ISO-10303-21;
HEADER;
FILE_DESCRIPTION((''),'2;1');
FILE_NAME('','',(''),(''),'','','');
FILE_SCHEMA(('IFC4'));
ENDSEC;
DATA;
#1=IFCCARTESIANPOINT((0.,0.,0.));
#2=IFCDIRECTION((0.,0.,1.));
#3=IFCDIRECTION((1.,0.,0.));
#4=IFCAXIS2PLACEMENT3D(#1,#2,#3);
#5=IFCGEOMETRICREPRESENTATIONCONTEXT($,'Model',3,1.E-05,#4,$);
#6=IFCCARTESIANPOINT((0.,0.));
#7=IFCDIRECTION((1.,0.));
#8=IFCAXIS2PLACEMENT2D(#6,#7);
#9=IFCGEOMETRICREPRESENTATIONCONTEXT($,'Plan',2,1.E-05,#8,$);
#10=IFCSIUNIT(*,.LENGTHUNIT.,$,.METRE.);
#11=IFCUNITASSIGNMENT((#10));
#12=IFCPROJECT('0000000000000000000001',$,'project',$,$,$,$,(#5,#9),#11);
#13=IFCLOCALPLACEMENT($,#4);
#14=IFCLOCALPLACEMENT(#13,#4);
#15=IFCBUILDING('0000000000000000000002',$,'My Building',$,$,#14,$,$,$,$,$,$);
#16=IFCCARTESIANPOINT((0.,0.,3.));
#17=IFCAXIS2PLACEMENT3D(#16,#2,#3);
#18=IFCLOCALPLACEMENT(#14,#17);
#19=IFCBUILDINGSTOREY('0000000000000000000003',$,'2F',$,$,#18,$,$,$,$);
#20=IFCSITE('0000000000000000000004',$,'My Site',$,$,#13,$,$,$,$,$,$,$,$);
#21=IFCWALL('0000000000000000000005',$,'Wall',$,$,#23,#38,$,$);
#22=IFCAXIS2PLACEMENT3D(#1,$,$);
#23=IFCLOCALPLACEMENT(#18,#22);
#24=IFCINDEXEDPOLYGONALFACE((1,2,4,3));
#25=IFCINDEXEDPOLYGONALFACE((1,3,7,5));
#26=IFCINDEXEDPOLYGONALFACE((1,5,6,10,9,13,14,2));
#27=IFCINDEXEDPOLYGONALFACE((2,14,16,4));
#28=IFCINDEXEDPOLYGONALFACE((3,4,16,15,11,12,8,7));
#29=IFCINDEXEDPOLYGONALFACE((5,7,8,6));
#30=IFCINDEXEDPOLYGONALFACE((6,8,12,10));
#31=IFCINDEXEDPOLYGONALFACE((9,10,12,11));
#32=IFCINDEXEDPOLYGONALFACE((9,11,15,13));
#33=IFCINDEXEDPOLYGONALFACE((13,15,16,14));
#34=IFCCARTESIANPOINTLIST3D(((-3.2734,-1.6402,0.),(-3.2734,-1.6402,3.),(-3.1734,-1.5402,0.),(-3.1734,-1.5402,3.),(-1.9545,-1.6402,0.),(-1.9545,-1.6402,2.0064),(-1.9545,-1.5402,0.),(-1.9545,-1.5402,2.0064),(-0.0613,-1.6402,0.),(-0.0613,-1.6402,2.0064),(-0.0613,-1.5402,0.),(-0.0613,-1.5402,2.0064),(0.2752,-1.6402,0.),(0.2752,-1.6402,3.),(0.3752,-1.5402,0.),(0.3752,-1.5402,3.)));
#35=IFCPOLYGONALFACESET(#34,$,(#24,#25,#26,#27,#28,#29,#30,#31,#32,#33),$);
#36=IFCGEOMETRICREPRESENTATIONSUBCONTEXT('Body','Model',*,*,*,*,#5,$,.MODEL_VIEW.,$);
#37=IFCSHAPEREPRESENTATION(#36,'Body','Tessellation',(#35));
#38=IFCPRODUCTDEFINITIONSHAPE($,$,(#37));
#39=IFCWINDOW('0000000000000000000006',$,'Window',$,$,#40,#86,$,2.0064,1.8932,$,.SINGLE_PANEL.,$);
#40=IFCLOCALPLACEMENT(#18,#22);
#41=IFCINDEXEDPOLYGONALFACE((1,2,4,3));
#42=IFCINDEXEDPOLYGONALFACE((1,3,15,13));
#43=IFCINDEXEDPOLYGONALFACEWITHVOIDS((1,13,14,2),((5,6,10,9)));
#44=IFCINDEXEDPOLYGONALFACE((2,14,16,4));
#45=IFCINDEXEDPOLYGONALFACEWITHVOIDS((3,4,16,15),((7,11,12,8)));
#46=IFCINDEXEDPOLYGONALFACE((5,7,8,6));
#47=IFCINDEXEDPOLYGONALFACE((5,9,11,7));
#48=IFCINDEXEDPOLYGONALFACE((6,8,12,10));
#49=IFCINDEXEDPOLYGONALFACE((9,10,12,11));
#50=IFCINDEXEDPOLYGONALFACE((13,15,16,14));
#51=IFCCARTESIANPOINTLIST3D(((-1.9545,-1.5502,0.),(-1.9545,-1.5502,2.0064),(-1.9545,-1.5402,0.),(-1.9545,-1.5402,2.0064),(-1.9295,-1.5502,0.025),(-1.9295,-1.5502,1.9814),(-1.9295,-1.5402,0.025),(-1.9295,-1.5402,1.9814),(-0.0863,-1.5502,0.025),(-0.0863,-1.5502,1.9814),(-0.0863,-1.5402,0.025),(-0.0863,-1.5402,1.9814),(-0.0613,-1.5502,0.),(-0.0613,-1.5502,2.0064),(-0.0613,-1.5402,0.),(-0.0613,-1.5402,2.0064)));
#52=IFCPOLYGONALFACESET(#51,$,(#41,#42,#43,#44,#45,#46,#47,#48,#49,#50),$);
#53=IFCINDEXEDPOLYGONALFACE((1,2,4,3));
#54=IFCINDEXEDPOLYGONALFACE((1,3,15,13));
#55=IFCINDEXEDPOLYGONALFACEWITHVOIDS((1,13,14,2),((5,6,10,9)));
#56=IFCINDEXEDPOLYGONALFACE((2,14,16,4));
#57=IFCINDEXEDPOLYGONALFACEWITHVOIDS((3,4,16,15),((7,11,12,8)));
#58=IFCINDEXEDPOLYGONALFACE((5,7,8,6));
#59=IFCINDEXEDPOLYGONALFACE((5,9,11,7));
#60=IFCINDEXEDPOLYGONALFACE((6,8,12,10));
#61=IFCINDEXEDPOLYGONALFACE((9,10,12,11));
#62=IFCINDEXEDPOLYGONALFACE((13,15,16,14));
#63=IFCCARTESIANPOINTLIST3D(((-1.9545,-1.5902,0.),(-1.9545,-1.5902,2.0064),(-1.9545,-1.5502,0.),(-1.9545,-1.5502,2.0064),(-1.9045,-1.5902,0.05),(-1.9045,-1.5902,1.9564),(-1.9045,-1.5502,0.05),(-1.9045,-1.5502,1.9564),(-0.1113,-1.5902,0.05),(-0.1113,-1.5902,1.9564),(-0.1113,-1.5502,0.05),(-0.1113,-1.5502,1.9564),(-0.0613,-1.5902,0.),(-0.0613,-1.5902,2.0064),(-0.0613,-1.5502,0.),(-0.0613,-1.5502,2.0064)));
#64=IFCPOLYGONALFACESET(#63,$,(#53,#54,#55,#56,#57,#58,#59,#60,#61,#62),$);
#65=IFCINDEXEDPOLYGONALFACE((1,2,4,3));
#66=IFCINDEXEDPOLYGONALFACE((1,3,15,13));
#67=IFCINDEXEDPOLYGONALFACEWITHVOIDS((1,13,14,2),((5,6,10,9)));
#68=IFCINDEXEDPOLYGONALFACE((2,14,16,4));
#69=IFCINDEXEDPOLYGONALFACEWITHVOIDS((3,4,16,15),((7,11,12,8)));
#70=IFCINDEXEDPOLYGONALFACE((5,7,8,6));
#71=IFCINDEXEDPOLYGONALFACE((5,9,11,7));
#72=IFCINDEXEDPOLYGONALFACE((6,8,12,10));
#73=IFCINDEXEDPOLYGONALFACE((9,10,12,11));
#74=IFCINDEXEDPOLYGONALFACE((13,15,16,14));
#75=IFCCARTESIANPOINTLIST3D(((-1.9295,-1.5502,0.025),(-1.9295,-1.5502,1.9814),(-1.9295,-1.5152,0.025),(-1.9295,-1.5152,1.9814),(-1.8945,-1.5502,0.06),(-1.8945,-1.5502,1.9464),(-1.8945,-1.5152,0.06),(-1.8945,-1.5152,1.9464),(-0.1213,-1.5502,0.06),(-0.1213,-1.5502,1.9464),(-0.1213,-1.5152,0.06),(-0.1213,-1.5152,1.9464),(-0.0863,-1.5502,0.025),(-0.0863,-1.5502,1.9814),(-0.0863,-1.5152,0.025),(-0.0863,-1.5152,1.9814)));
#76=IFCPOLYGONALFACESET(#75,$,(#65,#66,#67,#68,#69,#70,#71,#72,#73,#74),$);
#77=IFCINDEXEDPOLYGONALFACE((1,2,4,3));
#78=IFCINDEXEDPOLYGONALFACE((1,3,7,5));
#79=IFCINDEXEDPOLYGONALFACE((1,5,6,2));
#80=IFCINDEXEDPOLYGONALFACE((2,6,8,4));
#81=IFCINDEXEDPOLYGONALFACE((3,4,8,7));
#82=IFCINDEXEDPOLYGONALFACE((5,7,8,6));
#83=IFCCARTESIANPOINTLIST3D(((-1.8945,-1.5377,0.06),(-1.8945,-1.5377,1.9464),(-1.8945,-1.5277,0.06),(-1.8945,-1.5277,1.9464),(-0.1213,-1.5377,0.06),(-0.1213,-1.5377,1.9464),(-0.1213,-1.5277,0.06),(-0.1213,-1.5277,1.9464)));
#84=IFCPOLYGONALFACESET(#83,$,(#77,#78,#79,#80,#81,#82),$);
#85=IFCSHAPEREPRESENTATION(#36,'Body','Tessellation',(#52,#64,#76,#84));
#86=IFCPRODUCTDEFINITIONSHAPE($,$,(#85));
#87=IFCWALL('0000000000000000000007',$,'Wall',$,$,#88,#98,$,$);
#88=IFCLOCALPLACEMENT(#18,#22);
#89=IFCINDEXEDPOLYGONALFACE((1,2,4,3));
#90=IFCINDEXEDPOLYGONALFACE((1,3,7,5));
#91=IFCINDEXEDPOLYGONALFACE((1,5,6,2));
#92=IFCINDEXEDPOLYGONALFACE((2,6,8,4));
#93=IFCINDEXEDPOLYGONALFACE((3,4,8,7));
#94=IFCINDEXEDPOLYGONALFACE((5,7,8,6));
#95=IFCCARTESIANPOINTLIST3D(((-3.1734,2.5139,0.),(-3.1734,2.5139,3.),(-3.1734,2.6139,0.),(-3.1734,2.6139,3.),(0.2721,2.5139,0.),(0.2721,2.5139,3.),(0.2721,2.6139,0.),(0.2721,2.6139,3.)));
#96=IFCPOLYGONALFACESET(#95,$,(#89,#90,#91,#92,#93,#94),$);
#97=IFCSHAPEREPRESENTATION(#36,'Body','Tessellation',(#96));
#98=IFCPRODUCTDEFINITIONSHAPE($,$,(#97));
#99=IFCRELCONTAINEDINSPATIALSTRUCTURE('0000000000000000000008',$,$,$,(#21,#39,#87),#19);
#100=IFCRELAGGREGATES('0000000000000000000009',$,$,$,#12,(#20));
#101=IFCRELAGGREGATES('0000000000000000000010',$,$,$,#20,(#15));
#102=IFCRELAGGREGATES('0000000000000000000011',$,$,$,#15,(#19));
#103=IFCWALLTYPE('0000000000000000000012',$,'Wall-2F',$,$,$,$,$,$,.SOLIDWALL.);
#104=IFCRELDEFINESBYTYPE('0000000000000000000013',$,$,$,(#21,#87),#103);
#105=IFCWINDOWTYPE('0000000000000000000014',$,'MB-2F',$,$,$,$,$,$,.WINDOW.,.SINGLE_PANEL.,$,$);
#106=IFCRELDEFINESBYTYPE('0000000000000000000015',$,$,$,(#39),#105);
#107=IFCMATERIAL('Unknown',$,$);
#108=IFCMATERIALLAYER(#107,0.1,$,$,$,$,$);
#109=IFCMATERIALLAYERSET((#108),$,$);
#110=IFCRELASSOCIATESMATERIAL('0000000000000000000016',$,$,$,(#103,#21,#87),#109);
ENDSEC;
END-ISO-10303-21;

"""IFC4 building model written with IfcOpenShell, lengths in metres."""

from ifc_helpers import new_model, entity, si_unit, frame, origin_with_axes, origin_2d_with_axis, place, context, subcontext, project, spatial, line, indexed_curve, outline, extrude, shape, source, transform, mapped, material, layer, layer_set, layer_usage, type_object, type_shapes, element, fill, save


model = new_model("IFC4")

# Units and contexts
model_context = context("Model", 3, precision=1e-05, world=origin_with_axes())
plan_context = context("Plan", 2, precision=1e-05, world=origin_2d_with_axis())
body_context_1 = subcontext(model_context, "Body", "Model", "MODEL_VIEW")
body_context_2 = subcontext(plan_context, "Body", "Plan", "PLAN_VIEW")
ifc_project = project(units=[si_unit("LENGTHUNIT", "METRE")], contexts=[model_context, plan_context])

# Site, building, storey
site_placement = place(None, origin_with_axes())
site = spatial("IfcSite", under=ifc_project, at=site_placement, Name="My Site")
building_placement = place(site_placement, origin_with_axes())
building = spatial("IfcBuilding", under=site, at=building_placement, Name="My Building")
storey_placement = place(building_placement, frame((0.0, 0.0, 3.0), z_axis=(0.0, 0.0, 1.0), x_axis=(1.0, 0.0, 0.0)))
storey = spatial("IfcBuildingStorey", under=building, at=storey_placement, Name="2F")

# Shared definitions
ifc_material = material(Name="Unknown")

# Shared definitions
ifc_layer_1 = layer(ifc_material, 0.1)
ifc_layer_set_1 = layer_set([ifc_layer_1])
wall_type = type_object("IfcWallType", Name="Wall-2F", PredefinedType="SOLIDWALL", material=ifc_layer_set_1)

# Wall, opening, window
ifc_layer_usage_1 = layer_usage(ifc_layer_set_1, "AXIS2", "POSITIVE", 0.0)
wall_1_placement = place(storey_placement, frame((-3.2734, -1.6402, 0.0), z_axis=(0.0, 0.0, 1.0), x_axis=(1.0, 0.0, 0.0)))
wall_1 = element("IfcWall", 1, at=wall_1_placement, inside=storey, type_object=wall_type, material=ifc_layer_usage_1, Name="Wall", context=body_context_1, shape_type="SweptSolid", body=[
    extrude(outline(indexed_curve([(0.0, 0.0), (0.1, 0.1), (3.6485, 0.1), (3.5485, 0.0)], segments=[line(1, 2, 3, 4, 1)])), origin_with_axes(), (0.0, 0.0, 1.0), 3.0),
])
shared_shape_1 = source(origin_with_axes(), body_context_1, "Body", "SweptSolid", [
    extrude(outline(indexed_curve([(0.0, 0.0), (1.8932, 0.0), (1.8932, 2.0064), (0.0, 2.0064)], segments=[line(1, 2, 3, 4, 1)])), frame((0.0, -0.6, 0.0), z_axis=(0.0, -1.0, 0.0), x_axis=(1.0, 0.0, 0.0)), (0.0, 0.0, -1.0), 1.2),
])
opening_1_placement = place(wall_1_placement, frame((1.3189, 0.0, 0.0), z_axis=(0.0, 0.0, 1.0), x_axis=(1.0, 0.0, 0.0)))
opening_1 = element("IfcOpeningElement", 2, at=opening_1_placement, cuts=wall_1, PredefinedType="OPENING", context=body_context_1, shape_type="MappedRepresentation", body=[
    mapped(shared_shape_1, transform((0.0, 0.0, 0.0), x_axis=(1.0, 0.0, 0.0), y_axis=(0.0, 1.0, 0.0), z_axis=(0.0, 0.0, 1.0), scale=1.0)),
])
window_type_1 = type_object("IfcWindowType", Name="MB-2F", PartitioningType="SINGLE_PANEL", PredefinedType="WINDOW")
shared_shape_2 = source(origin_with_axes(), body_context_1, "Body", "SweptSolid", [
    extrude(outline(indexed_curve([(0.0, 0.0), (1.8932, 0.0), (1.8932, 2.0064), (0.0, 2.0064)], segments=[line(1, 2, 3, 4, 1)]), holes=[indexed_curve([(0.025, 0.025), (1.8682, 0.025), (1.8682, 1.9814), (0.025, 1.9814)], segments=[line(1, 2, 3, 4, 1)])]), frame((0.0, 0.09, 0.0), z_axis=(0.0, -1.0, 0.0), x_axis=(1.0, 0.0, 0.0)), (0.0, 0.0, -1.0), 0.01),
    extrude(outline(indexed_curve([(0.0, 0.0), (1.8932, 0.0), (1.8932, 2.0064), (0.0, 2.0064)], segments=[line(1, 2, 3, 4, 1)]), holes=[indexed_curve([(0.05, 0.05), (1.8432, 0.05), (1.8432, 1.9564), (0.05, 1.9564)], segments=[line(1, 2, 3, 4, 1)])]), frame((0.0, 0.05, 0.0), z_axis=(0.0, -1.0, 0.0), x_axis=(1.0, 0.0, 0.0)), (0.0, 0.0, -1.0), 0.04),
    extrude(outline(indexed_curve([(0.0, 0.0), (1.8432, 0.0), (1.8432, 1.9564), (0.0, 1.9564)], segments=[line(1, 2, 3, 4, 1)]), holes=[indexed_curve([(0.035, 0.035), (1.8082, 0.035), (1.8082, 1.9214), (0.035, 1.9214)], segments=[line(1, 2, 3, 4, 1)])]), frame((0.025, 0.09, 0.025), z_axis=(0.0, -1.0, 0.0), x_axis=(1.0, 0.0, 0.0)), (0.0, 0.0, -1.0), 0.035),
    extrude(outline(indexed_curve([(0.035, 0.035), (1.8082, 0.035), (1.8082, 1.9214), (0.035, 1.9214)], segments=[line(1, 2, 3, 4, 1)])), frame((0.025, 0.1025, 0.025), z_axis=(0.0, -1.0, 0.0), x_axis=(1.0, 0.0, 0.0)), (0.0, 0.0, -1.0), 0.01),
])
shared_shape_3 = source(origin_with_axes(), body_context_2, "Body", "Curve2D", [
    entity("IfcIndexedPolyCurve", entity("IfcCartesianPointList2D", [[0.05, 0.05], [1.8432, 0.05]])),
    entity("IfcIndexedPolyCurve", entity("IfcCartesianPointList2D", [[0.0, 0.1], [0.025, 0.1], [0.025, 0.09], [0.05, 0.09], [0.05, 0.05], [0.0, 0.05]]), [entity("IfcLineIndex", [1, 2, 3, 4, 5, 6, 1])]),
    entity("IfcIndexedPolyCurve", entity("IfcCartesianPointList2D", [[1.8932, 0.1], [1.8682, 0.1], [1.8682, 0.09], [1.8432, 0.09], [1.8432, 0.05], [1.8932, 0.05]]), [entity("IfcLineIndex", [1, 2, 3, 4, 5, 6, 1])]),
    entity("IfcIndexedPolyCurve", entity("IfcCartesianPointList2D", [[0.025, 0.09], [0.06, 0.09], [0.06, 0.125], [0.025, 0.125]]), [entity("IfcLineIndex", [1, 2, 3, 4, 1])]),
    entity("IfcIndexedPolyCurve", entity("IfcCartesianPointList2D", [[1.8682, 0.09], [1.8332, 0.09], [1.8332, 0.125], [1.8682, 0.125]]), [entity("IfcLineIndex", [1, 2, 3, 4, 1])]),
    entity("IfcIndexedPolyCurve", entity("IfcCartesianPointList2D", [[0.06, 0.09], [1.8332, 0.09]])),
    entity("IfcIndexedPolyCurve", entity("IfcCartesianPointList2D", [[0.06, 0.125], [1.8332, 0.125]])),
    entity("IfcIndexedPolyCurve", entity("IfcCartesianPointList2D", [[0.06, 0.1075], [1.8332, 0.1075]])),
])
type_shapes(window_type_1, [shared_shape_2, shared_shape_3])
window_1_placement = place(opening_1_placement, origin_with_axes())
window_1 = element("IfcWindow", 3, at=window_1_placement, inside=storey, type_object=window_type_1, Name="Window", OverallHeight=2.0064, OverallWidth=1.8932, PartitioningType="SINGLE_PANEL", shapes=[
    shape(body_context_1, "Body", "MappedRepresentation", [mapped(shared_shape_2, transform((0.0, 0.0, 0.0), x_axis=(1.0, 0.0, 0.0), y_axis=(0.0, 1.0, 0.0), z_axis=(0.0, 0.0, 1.0), scale=1.0))]),
    shape(body_context_2, "Body", "MappedRepresentation", [mapped(shared_shape_3, transform((0.0, 0.0, 0.0), x_axis=(1.0, 0.0, 0.0), y_axis=(0.0, 1.0, 0.0), z_axis=(0.0, 0.0, 1.0), scale=1.0))]),
])
fill(opening_1, window_1)

# Wall
ifc_layer_usage_2 = layer_usage(ifc_layer_set_1, "AXIS2", "POSITIVE", 0.0)
wall_2_placement = place(storey_placement, frame((0.2721, 2.6139, 0.0), z_axis=(0.0, 0.0, 1.0), x_axis=(-1.0, 0.0, 0.0)))
element("IfcWall", 4, at=wall_2_placement, inside=storey, type_object=wall_type, material=ifc_layer_usage_2, Name="Wall", context=body_context_1, shape_type="SweptSolid", body=[
    extrude(outline(indexed_curve([(0.0, 0.0), (0.0, 0.1), (3.4454, 0.1), (3.4454, 0.0)], segments=[line(1, 2, 3, 4, 1)])), origin_with_axes(), (0.0, 0.0, 1.0), 3.0),
])

save(model, "model.ifc")
